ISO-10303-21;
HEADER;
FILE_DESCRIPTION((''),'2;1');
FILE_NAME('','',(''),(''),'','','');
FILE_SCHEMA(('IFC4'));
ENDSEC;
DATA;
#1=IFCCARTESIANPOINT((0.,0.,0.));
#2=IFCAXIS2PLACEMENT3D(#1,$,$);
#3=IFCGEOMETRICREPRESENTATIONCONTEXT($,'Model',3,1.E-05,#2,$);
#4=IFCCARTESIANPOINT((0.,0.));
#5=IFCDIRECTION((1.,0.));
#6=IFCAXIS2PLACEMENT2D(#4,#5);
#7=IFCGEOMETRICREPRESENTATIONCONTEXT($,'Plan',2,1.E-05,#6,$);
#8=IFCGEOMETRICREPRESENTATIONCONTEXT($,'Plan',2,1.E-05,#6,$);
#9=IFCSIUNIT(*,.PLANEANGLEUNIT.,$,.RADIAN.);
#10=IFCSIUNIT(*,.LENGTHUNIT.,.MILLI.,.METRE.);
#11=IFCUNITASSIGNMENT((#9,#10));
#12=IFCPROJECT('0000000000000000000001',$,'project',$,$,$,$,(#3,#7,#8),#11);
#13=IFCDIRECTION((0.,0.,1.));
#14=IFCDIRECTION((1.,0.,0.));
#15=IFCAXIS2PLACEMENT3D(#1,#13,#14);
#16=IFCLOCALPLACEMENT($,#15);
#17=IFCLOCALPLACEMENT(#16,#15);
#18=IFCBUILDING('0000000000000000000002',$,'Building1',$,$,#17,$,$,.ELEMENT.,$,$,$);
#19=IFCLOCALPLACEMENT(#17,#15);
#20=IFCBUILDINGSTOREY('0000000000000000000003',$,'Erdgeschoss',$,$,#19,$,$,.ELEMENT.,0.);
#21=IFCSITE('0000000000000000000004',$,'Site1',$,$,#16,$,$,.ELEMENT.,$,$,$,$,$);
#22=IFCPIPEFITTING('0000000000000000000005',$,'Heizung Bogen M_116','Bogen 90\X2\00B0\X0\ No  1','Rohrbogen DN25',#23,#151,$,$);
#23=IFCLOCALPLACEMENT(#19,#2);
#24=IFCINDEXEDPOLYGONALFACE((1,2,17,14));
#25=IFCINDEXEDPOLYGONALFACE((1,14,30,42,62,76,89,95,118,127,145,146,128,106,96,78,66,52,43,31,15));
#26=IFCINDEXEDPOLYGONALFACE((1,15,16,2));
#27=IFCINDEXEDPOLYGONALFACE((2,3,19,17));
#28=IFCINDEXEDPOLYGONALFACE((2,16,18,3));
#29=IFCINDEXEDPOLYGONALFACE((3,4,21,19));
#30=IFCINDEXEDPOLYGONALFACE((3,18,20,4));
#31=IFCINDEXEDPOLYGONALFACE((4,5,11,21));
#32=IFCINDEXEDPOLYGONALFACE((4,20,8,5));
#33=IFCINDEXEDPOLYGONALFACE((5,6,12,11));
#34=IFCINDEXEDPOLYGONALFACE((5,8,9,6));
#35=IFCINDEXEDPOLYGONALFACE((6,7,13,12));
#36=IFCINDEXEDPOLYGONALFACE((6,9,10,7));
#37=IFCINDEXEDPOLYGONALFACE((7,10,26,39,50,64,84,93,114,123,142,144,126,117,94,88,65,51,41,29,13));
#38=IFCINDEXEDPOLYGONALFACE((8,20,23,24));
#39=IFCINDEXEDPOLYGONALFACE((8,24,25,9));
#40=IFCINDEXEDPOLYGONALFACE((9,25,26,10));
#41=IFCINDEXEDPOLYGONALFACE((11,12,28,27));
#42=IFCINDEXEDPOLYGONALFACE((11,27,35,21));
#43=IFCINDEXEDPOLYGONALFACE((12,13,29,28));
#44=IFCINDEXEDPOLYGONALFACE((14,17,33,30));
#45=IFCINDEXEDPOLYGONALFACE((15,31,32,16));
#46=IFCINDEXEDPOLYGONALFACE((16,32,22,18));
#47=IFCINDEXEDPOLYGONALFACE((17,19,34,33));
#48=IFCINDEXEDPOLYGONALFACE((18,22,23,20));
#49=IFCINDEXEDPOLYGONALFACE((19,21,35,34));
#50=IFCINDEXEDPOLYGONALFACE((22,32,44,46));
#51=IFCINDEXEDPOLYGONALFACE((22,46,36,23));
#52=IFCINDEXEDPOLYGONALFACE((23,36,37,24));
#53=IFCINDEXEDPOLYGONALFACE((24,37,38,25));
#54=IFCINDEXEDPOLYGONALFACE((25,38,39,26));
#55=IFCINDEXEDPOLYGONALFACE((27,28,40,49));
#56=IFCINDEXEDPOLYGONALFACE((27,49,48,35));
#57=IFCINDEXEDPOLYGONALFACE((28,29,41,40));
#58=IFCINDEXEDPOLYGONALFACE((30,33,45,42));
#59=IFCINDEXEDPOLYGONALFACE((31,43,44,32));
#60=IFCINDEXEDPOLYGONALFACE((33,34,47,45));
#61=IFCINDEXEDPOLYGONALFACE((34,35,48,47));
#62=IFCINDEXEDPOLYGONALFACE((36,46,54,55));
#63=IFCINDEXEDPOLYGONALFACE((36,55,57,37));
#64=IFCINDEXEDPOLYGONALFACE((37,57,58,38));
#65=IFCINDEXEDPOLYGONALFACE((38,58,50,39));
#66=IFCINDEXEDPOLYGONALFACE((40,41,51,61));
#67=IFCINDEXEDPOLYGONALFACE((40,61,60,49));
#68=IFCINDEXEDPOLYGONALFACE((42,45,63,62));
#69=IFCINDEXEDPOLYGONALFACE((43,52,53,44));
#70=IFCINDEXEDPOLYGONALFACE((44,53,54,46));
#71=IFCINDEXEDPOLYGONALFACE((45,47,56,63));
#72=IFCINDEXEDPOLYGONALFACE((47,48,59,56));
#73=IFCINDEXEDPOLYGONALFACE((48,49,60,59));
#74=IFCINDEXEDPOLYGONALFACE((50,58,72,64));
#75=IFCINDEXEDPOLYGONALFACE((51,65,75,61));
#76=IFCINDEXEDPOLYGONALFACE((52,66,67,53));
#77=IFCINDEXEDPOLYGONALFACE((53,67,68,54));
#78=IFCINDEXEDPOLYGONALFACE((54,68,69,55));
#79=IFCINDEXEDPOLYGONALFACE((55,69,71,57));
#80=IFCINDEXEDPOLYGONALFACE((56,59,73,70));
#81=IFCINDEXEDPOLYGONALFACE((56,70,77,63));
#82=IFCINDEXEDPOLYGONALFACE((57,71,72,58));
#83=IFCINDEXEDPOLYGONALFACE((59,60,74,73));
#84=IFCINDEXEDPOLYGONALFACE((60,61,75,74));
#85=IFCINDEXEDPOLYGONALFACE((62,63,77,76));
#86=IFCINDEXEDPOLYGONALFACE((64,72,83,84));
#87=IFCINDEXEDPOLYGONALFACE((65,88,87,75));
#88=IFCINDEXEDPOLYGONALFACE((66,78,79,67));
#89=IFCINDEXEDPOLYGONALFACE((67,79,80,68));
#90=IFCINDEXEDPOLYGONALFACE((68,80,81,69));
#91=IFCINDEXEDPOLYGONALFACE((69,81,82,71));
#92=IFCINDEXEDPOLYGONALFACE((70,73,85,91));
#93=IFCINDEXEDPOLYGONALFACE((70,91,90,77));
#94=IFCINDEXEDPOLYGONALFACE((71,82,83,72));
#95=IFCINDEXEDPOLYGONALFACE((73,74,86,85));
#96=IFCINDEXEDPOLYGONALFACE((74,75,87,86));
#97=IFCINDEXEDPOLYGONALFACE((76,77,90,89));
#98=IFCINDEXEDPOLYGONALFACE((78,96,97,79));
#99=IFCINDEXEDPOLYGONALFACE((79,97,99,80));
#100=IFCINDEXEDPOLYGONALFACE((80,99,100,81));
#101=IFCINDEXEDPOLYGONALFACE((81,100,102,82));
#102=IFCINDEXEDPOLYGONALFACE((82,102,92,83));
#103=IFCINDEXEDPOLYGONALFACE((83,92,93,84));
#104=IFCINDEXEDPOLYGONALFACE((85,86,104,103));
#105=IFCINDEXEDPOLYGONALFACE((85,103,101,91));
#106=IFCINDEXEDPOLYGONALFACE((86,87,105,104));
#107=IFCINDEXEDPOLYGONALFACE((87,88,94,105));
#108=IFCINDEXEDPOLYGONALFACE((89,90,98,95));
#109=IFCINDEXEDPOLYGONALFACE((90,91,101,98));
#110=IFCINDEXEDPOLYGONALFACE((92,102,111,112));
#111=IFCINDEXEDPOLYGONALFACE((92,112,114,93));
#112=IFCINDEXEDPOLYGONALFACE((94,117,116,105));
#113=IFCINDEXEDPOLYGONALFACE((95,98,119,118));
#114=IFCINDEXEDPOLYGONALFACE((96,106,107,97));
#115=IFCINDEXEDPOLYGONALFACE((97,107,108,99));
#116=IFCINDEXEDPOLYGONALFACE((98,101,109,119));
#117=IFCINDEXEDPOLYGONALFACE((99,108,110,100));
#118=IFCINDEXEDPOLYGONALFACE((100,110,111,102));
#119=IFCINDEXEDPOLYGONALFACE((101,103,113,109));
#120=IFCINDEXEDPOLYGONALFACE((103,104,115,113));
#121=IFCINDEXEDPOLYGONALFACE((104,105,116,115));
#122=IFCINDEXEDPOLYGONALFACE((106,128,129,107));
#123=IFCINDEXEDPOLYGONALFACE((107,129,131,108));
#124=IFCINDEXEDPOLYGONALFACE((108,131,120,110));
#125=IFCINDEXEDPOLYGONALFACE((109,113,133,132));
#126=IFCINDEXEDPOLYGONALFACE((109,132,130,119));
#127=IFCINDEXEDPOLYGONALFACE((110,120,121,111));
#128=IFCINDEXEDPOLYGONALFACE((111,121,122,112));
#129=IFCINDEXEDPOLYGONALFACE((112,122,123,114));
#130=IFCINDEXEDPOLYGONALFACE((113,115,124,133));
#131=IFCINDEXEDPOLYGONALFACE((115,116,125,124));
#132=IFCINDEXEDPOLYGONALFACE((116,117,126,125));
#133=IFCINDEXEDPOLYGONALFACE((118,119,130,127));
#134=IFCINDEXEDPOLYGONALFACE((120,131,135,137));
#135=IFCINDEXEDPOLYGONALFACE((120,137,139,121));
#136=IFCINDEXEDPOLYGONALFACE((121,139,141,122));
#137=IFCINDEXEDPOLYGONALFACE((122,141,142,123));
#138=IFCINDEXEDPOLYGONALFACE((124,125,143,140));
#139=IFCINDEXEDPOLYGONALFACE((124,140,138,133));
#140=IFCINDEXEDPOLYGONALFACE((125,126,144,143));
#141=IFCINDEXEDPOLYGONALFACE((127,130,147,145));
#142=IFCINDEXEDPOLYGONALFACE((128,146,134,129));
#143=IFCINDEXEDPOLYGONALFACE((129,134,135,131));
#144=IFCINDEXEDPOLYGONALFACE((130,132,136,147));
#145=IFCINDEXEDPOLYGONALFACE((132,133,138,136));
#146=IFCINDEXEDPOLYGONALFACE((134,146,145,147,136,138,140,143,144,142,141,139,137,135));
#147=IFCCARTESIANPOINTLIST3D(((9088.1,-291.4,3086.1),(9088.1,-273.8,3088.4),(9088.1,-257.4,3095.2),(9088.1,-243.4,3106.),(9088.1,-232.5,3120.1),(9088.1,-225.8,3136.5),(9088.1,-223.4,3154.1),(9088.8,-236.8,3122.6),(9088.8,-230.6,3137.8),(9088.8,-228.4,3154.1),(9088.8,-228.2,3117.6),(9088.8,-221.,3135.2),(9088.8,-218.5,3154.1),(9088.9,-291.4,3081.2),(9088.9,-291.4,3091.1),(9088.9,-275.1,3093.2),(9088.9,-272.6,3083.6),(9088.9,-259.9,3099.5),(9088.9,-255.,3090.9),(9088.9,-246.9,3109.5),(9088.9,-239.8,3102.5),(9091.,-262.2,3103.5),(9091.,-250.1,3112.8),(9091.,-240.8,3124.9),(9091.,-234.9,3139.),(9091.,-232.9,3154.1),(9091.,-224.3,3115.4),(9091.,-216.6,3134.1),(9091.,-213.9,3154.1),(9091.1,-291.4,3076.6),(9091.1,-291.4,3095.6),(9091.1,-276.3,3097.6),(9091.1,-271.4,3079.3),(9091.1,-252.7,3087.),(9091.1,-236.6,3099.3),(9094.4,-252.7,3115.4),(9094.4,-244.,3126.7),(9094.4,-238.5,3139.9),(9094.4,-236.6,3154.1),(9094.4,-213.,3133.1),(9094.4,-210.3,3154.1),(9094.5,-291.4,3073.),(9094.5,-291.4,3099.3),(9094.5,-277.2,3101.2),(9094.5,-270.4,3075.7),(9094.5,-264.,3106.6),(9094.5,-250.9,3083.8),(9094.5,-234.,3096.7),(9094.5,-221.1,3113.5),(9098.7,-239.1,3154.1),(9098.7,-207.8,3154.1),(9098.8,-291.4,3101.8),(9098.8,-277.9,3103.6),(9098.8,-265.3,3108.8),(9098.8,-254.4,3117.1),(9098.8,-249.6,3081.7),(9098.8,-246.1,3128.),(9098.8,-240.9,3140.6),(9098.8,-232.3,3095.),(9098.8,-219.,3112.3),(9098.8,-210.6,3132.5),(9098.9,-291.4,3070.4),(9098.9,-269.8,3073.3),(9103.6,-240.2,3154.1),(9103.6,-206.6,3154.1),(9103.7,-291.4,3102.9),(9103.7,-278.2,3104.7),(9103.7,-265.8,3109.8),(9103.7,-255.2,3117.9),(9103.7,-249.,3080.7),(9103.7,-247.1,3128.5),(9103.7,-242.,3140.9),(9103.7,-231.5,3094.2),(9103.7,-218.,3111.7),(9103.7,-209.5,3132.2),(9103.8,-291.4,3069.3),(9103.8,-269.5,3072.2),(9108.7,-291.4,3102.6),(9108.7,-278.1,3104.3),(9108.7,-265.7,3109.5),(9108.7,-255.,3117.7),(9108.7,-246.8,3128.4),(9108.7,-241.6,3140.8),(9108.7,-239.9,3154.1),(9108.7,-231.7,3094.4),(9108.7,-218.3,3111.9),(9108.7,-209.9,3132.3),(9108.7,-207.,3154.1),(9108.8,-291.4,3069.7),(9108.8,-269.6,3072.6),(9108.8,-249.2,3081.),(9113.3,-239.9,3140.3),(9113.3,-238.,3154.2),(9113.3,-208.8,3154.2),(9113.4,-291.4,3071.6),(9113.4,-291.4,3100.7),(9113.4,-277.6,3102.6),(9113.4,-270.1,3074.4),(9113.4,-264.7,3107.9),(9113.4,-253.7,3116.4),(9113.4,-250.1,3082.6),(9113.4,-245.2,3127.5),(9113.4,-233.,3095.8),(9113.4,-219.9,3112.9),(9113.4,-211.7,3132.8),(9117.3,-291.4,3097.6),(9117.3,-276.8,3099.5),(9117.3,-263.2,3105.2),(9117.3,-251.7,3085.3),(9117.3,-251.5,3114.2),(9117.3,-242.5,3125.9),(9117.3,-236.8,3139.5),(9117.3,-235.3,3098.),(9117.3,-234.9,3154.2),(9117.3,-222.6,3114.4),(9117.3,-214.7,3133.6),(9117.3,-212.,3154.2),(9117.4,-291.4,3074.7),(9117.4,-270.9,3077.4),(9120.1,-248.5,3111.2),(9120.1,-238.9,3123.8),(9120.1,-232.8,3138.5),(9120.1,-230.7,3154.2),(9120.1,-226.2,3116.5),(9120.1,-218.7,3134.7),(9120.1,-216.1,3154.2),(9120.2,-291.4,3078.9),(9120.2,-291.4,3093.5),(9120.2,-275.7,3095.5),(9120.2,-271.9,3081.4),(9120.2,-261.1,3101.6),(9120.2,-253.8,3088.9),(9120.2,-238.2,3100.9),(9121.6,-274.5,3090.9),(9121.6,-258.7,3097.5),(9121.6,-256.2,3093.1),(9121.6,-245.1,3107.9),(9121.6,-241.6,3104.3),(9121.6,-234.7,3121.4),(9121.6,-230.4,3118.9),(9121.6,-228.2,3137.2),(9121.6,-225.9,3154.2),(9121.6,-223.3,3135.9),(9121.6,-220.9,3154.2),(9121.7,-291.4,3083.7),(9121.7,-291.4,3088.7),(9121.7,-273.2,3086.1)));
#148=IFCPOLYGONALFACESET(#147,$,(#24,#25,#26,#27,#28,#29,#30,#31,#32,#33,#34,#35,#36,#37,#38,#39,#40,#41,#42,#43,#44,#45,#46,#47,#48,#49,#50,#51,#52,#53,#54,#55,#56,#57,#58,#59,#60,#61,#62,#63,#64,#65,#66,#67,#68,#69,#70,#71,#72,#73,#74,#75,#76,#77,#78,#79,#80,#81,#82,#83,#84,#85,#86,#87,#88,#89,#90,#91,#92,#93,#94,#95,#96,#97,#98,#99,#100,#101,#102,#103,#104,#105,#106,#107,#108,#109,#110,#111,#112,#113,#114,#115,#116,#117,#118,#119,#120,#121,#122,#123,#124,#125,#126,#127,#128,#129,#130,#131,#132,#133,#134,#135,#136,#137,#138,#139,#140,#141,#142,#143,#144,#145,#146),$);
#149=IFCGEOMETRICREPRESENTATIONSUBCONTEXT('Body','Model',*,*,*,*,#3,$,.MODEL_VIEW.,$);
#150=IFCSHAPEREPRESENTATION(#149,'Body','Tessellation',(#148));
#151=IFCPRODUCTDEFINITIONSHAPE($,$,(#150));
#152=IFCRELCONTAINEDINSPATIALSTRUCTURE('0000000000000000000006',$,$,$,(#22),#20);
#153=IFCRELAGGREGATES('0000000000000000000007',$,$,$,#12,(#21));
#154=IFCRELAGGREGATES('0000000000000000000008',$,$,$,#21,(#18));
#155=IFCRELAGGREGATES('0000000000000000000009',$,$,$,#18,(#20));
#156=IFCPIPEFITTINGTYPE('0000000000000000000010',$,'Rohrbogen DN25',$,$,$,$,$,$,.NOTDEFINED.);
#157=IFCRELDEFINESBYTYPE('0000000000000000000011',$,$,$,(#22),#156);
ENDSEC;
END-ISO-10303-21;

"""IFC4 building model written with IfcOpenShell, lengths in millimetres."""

from ifc_helpers import new_model, entity, si_unit, frame, origin, origin_with_axes, origin_2d_with_axis, place, context, subcontext, project, spatial, source, transform, mapped, type_object, element, save


model = new_model("IFC4")

# Units and contexts
model_context = context("Model", 3, precision=1e-05, world=origin())
plan_context_1 = context("Plan", 2, precision=1e-05, world=origin_2d_with_axis())
plan_context_2 = context("Plan", 2, precision=1e-05, world=origin_2d_with_axis())
body_context = subcontext(model_context, "Body", "Model", "MODEL_VIEW")
ifc_project = project(units=[si_unit("PLANEANGLEUNIT", "RADIAN"), si_unit("LENGTHUNIT", "METRE", prefix="MILLI")], contexts=[model_context, plan_context_1, plan_context_2])

# Site, building, storey
site_placement = place(None, origin_with_axes())
site = spatial("IfcSite", under=ifc_project, at=site_placement, Name="Site1", CompositionType="ELEMENT")
building_placement = place(site_placement, origin_with_axes())
building = spatial("IfcBuilding", under=site, at=building_placement, Name="Building1", CompositionType="ELEMENT")
storey_placement = place(building_placement, origin_with_axes())
storey = spatial("IfcBuildingStorey", under=building, at=storey_placement, Name="Erdgeschoss", CompositionType="ELEMENT", Elevation=0.0)

# Pipe fitting
pipe_fitting_type = type_object("IfcPipeFittingType", Name="Rohrbogen DN25", PredefinedType="NOTDEFINED")
shared_shape_1 = source(origin_with_axes(), body_context, "Body", "SolidModel", [
    entity("IfcRevolvedAreaSolid", entity("IfcCircleProfileDef", "AREA", None, entity("IfcAxis2Placement2D", entity("IfcCartesianPoint", [0.0, 0.0]), entity("IfcDirection", [1.0, 0.0])), 16.9), entity("IfcAxis2Placement3D", entity("IfcCartesianPoint", [-42.4, 0.0, 25.6]), entity("IfcDirection", [1.0, 0.0, 0.0]), entity("IfcDirection", [0.0, -0.999999, 0.001364])), entity("IfcAxis1Placement", entity("IfcCartesianPoint", [0.0, 68.0, 0.0]), entity("IfcDirection", [-1.0, 0.0, 0.0])), 1.570796),
])
pipe_fitting_1_placement = place(storey_placement, frame((9105.0, -249.0, 3111.7), z_axis=(0.0, 0.0, 1.0), x_axis=(1.0, 0.0, 0.0)))
element("IfcPipeFitting", 1, at=pipe_fitting_1_placement, inside=storey, type_object=pipe_fitting_type, Name="Heizung Bogen M_116", Description="Bogen 90° No  1", ObjectType="Rohrbogen DN25", context=body_context, shape_type="MappedRepresentation", body=[
    mapped(shared_shape_1, transform((0.0, 0.0, 0.0), x_axis=(0.0, 1.0, 0.0), y_axis=(1.0, 0.0, 0.0), z_axis=(0.0, 0.0, -1.0), scale=1.0)),
])

save(model, "model.ifc")
